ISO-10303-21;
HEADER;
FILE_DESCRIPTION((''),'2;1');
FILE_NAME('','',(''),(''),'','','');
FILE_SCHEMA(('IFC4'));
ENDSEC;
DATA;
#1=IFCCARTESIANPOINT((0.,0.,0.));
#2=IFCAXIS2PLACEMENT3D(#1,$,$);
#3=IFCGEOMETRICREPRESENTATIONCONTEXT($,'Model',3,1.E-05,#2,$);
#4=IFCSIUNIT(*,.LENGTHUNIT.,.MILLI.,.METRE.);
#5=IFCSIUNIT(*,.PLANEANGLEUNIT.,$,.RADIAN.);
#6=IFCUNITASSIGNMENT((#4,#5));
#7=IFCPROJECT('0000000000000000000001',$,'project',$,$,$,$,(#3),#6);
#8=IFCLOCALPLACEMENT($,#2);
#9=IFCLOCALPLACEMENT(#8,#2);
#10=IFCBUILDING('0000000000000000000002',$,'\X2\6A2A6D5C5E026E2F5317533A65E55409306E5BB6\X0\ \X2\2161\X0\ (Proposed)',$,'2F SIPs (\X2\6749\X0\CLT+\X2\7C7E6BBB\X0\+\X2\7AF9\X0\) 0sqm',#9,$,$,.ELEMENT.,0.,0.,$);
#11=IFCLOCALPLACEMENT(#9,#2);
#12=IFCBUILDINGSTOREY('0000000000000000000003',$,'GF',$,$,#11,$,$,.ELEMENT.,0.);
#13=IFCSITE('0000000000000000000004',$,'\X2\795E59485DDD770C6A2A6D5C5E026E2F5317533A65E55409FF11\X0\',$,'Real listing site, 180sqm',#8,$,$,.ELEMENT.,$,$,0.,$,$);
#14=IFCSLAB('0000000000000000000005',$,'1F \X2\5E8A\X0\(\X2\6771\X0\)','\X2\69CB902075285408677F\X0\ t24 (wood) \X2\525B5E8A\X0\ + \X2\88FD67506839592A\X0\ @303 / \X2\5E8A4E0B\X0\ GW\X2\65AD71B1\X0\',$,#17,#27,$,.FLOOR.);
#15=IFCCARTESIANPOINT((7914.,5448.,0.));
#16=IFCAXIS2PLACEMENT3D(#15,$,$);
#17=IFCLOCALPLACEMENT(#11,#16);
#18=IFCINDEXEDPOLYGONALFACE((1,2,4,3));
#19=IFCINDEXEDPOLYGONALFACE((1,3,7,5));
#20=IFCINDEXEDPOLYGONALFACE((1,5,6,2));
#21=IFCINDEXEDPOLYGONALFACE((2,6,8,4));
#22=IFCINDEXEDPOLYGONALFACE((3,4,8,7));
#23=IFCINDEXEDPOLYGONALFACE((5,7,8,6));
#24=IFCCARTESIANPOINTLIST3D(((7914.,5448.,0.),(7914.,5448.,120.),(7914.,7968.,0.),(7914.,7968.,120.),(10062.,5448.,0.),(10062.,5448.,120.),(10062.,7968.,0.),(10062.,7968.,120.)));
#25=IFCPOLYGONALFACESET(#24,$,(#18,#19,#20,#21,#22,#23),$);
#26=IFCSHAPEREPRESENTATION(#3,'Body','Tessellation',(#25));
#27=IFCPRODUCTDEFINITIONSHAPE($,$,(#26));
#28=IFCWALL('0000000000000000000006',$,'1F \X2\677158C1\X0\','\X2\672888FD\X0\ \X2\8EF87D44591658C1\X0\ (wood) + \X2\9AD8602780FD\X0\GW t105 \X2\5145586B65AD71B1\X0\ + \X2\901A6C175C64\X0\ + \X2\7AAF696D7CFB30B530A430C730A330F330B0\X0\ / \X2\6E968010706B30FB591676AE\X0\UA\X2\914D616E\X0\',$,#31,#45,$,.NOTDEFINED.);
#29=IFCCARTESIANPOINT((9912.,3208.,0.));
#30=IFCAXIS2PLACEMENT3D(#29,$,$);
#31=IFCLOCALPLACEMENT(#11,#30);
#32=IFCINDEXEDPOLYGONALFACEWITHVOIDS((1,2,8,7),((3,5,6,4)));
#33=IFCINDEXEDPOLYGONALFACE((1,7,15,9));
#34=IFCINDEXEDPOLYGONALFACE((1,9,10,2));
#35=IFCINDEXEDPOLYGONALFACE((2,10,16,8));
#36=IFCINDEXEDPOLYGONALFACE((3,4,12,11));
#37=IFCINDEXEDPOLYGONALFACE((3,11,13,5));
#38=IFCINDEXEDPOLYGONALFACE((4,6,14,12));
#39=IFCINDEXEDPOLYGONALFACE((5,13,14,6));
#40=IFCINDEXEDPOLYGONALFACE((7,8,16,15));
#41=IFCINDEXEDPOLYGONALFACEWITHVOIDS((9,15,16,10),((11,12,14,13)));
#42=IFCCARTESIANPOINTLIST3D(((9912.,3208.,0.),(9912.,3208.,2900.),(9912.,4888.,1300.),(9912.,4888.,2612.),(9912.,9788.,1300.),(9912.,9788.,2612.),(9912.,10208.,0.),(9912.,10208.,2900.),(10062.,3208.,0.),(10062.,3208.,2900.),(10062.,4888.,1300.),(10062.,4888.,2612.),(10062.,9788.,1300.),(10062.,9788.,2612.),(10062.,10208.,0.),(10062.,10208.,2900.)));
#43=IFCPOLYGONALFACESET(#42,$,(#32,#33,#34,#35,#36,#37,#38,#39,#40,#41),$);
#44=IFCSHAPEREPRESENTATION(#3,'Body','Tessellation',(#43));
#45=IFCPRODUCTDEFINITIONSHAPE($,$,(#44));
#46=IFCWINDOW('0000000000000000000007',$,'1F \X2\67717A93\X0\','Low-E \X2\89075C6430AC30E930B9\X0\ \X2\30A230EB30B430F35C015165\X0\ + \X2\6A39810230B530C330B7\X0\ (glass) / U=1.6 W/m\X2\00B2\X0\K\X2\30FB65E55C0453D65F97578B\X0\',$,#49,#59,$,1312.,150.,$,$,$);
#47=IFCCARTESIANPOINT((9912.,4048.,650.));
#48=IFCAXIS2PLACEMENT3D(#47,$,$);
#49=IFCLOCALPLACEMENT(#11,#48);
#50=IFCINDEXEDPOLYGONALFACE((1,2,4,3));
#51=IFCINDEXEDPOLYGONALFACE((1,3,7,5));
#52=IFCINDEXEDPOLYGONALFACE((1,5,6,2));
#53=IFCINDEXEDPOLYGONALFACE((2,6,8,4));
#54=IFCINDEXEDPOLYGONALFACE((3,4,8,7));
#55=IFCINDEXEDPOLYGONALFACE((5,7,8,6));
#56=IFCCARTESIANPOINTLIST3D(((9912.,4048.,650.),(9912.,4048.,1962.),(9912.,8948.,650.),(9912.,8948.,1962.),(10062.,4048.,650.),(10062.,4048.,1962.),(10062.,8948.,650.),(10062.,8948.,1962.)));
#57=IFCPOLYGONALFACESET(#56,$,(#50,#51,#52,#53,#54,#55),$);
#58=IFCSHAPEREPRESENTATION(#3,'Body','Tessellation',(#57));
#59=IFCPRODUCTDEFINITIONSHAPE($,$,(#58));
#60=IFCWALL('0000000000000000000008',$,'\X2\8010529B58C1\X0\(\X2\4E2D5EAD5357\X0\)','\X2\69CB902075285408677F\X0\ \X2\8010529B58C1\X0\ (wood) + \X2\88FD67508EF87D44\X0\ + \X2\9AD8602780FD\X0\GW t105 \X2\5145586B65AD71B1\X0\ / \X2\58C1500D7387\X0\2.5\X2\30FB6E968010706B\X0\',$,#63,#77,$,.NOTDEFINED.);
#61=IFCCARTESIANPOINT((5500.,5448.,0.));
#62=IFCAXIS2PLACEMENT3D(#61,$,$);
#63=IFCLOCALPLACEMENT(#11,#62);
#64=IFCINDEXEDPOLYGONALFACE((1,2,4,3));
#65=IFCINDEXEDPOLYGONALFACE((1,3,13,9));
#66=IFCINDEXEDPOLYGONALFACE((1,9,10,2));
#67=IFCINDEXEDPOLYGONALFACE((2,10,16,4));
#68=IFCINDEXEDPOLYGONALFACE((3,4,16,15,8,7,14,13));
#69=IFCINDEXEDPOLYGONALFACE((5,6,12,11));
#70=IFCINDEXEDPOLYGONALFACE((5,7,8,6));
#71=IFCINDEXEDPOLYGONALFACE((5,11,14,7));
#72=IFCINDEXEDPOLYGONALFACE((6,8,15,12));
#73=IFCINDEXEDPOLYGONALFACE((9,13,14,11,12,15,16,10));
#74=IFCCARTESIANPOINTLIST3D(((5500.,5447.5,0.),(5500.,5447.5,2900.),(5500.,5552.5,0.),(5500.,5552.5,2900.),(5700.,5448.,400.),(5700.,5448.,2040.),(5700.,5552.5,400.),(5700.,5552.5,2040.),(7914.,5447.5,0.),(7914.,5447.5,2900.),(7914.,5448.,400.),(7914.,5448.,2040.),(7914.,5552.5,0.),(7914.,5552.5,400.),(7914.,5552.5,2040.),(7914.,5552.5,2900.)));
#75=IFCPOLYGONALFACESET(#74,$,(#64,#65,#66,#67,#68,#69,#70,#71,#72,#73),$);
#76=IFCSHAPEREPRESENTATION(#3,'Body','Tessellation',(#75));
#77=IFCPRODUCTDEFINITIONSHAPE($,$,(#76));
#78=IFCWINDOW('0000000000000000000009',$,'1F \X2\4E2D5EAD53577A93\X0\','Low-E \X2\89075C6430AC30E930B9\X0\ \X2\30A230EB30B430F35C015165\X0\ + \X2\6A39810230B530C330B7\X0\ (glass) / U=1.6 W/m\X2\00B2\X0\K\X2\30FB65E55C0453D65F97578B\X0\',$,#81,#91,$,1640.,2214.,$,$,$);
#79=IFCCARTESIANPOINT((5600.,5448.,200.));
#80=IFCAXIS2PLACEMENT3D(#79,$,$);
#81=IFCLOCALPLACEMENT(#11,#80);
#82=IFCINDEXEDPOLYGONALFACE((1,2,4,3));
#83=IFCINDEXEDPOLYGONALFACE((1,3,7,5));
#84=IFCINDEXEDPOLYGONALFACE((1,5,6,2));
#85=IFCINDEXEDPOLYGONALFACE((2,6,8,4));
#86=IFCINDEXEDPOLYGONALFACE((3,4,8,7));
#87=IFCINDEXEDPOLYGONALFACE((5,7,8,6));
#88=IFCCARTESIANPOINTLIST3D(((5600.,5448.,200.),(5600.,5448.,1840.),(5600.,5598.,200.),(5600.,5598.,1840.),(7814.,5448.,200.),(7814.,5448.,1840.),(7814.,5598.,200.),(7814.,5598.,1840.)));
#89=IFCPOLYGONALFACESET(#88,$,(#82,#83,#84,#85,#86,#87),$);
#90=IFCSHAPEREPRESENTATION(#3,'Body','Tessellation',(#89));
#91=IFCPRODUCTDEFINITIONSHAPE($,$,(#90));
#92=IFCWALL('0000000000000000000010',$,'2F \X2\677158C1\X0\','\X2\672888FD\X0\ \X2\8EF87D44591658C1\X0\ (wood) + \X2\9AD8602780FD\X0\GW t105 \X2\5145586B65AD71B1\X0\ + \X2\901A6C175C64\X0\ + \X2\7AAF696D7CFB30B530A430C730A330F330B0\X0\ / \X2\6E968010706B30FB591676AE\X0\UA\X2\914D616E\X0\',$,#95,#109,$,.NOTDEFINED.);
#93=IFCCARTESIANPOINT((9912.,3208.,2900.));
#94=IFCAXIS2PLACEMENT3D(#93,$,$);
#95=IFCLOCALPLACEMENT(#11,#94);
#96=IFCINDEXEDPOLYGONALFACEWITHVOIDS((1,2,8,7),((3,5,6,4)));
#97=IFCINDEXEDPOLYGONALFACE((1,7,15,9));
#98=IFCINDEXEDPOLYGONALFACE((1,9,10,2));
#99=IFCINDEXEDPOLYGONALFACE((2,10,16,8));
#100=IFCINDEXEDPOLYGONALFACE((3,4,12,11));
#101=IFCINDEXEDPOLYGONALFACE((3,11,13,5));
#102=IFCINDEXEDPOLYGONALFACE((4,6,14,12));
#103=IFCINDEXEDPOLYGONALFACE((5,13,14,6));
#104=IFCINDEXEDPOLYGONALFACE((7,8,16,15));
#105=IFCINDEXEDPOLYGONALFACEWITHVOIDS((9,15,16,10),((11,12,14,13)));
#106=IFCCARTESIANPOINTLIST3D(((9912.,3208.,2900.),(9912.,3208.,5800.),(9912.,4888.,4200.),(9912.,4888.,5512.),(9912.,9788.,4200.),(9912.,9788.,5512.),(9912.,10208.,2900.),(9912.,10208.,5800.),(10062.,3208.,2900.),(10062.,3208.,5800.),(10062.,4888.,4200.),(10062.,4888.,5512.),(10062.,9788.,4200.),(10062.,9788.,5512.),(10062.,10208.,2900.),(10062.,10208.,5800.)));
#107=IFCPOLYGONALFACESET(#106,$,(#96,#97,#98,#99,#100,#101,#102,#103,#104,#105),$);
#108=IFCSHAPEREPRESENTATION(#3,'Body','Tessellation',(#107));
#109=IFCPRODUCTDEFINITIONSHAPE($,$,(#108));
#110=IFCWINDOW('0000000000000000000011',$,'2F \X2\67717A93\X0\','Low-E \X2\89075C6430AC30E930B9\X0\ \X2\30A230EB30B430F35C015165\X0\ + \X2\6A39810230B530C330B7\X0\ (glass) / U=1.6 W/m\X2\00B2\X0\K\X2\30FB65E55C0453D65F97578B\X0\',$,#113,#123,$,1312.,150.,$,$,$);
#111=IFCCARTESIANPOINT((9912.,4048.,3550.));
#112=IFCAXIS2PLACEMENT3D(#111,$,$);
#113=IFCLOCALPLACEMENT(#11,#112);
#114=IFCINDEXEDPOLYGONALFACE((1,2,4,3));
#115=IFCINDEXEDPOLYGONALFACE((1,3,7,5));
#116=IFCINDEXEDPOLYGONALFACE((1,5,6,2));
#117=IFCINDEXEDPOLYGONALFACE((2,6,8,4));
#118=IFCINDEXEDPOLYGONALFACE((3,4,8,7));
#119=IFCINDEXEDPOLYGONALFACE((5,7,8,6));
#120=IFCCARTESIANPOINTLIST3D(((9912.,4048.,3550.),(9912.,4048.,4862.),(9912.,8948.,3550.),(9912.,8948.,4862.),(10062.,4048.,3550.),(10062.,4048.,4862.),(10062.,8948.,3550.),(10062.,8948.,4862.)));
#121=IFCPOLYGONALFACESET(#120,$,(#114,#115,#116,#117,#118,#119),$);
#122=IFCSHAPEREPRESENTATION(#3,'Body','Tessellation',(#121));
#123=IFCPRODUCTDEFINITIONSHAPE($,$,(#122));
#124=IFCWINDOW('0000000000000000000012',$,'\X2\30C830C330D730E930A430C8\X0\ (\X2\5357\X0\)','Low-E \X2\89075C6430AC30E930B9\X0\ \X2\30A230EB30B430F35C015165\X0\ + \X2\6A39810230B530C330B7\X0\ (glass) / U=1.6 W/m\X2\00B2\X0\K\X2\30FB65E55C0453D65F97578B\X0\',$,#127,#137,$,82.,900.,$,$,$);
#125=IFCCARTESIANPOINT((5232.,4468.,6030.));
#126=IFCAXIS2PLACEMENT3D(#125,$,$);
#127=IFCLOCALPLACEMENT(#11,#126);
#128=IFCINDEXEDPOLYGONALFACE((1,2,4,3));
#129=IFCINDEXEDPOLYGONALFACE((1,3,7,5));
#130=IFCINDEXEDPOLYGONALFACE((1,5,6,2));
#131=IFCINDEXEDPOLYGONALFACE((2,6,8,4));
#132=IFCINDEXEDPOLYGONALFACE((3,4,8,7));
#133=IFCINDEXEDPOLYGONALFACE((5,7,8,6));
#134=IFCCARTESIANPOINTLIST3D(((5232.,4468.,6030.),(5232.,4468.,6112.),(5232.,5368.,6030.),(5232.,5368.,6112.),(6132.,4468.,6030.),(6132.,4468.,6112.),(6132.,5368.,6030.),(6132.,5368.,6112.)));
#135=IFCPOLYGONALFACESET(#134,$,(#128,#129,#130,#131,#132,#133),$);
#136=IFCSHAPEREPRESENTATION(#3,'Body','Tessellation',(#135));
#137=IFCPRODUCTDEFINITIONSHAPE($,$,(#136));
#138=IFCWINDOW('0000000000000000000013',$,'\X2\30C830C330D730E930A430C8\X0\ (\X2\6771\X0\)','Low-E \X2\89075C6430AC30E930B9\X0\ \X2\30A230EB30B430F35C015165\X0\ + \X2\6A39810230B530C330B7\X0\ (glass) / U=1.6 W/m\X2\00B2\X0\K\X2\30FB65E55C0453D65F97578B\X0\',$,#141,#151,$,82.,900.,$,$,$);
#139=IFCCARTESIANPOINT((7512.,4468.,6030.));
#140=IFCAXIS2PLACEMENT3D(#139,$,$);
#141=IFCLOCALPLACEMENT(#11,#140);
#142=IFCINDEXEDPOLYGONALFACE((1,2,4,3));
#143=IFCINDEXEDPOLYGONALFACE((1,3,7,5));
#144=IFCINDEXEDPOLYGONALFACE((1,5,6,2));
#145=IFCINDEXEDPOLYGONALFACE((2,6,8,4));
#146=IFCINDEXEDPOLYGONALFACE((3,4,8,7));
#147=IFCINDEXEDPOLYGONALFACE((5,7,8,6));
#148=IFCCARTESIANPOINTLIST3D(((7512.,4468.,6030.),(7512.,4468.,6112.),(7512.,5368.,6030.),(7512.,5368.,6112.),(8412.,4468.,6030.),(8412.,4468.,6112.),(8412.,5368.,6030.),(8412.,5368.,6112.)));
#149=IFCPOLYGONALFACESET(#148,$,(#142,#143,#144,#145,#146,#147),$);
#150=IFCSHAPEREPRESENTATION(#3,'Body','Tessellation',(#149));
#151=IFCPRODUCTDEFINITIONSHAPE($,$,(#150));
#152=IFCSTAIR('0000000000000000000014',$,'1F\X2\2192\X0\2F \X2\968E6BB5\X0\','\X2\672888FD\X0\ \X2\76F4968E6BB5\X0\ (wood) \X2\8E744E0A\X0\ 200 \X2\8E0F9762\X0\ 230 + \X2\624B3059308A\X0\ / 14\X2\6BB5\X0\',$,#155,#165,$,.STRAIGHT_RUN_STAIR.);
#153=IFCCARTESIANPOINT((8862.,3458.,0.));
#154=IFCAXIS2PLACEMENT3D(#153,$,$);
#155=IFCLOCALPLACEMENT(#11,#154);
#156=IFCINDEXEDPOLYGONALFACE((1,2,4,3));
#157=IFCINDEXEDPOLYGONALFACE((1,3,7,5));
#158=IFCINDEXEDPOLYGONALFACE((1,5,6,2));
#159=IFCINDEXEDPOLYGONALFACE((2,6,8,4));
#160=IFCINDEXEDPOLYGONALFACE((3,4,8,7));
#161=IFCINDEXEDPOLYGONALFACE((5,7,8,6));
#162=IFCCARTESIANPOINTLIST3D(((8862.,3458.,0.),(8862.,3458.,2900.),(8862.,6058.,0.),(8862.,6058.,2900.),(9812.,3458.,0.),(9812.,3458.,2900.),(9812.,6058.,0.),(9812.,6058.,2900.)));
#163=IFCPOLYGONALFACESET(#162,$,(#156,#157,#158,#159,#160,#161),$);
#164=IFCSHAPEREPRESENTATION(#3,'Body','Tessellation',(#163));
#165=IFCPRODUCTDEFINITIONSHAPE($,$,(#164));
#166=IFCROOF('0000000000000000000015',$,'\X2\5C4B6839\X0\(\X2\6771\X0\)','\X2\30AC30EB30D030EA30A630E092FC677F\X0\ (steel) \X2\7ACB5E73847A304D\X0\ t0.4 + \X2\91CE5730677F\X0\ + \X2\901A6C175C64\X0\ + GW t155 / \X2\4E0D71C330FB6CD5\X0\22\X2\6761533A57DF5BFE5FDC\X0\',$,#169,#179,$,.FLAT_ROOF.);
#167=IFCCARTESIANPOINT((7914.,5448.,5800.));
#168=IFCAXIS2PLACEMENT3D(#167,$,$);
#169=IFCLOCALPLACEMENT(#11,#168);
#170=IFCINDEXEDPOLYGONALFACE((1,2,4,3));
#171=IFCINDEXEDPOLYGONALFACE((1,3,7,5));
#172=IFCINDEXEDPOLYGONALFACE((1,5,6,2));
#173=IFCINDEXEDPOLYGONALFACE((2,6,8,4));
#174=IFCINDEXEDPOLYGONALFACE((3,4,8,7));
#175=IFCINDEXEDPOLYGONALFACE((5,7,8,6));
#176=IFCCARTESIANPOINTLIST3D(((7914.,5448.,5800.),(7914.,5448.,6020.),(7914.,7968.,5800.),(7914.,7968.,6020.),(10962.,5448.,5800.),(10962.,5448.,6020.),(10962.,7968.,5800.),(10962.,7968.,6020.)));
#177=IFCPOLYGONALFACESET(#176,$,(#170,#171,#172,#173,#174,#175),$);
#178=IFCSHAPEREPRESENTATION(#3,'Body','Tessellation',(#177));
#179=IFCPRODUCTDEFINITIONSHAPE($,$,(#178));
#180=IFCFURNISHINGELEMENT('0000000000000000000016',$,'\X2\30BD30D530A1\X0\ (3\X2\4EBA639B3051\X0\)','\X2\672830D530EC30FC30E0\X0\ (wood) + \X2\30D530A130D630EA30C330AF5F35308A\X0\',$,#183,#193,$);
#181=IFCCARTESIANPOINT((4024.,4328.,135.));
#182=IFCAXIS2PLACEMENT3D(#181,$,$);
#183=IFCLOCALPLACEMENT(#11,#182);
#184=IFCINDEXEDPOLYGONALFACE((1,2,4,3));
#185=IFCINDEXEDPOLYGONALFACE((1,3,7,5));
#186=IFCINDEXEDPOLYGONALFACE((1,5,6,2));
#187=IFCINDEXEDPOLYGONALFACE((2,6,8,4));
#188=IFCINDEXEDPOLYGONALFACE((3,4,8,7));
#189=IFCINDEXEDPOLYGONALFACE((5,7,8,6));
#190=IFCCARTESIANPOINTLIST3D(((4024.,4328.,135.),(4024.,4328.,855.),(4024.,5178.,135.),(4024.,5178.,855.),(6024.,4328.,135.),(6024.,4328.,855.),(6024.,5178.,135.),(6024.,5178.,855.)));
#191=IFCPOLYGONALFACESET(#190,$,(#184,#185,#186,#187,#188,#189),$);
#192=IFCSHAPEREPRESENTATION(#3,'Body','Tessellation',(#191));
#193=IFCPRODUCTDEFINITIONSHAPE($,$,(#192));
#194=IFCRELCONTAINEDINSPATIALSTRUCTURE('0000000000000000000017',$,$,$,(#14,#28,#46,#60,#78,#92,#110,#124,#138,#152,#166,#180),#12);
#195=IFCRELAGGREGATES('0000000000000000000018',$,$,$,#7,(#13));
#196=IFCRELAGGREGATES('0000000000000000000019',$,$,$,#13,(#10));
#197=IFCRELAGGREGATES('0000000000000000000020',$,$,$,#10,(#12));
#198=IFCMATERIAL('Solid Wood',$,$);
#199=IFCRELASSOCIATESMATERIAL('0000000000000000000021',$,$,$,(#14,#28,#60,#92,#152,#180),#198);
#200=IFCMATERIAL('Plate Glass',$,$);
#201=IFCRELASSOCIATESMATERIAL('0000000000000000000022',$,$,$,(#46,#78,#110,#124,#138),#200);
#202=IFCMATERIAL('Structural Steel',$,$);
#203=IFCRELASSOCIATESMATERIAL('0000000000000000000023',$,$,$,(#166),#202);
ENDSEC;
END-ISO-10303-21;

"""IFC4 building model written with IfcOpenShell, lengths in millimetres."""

from ifc_helpers import new_model, si_unit, frame, frame_2d, origin, place, context, project, spatial, rectangle, extrude, material, element, fill, save


model = new_model("IFC4")

# Units and contexts
model_context = context("Model", 3, precision=1e-05, world=origin())
ifc_project = project(units=[si_unit("LENGTHUNIT", "METRE", prefix="MILLI"), si_unit("PLANEANGLEUNIT", "RADIAN")], contexts=[model_context])

# Site, building, storey
site_placement = place(None, origin())
site = spatial("IfcSite", under=ifc_project, at=site_placement, Name="神奈川県横浜市港北区日吉１", ObjectType="Real listing site, 180sqm", CompositionType="ELEMENT", RefElevation=0.0)
building_placement = place(site_placement, origin())
building = spatial("IfcBuilding", under=site, at=building_placement, Name="横浜市港北区日吉の家 Ⅱ (Proposed)", ObjectType="2F SIPs (杉CLT+籾殻+竹) 0sqm", CompositionType="ELEMENT", ElevationOfRefHeight=0.0, ElevationOfTerrain=0.0)
storey_placement = place(building_placement, origin())
storey = spatial("IfcBuildingStorey", under=building, at=storey_placement, Name="GF", CompositionType="ELEMENT", Elevation=0.0)

# Slab
ifc_material_1 = material(Name="Solid Wood")
slab_placement = place(storey_placement, frame((7914.0, 5448.0, 0.0)))
element("IfcSlab", 1, at=slab_placement, inside=storey, material=ifc_material_1, Name="1F 床(東)", Description="構造用合板 t24 (wood) 剛床 + 製材根太 @303 / 床下 GW断熱", PredefinedType="FLOOR", context=model_context, shape_type="SweptSolid", body=[
    extrude(rectangle(XDim=2148.0, YDim=2520.0, at=frame_2d((1074.0, 1260.0))), frame((7914.0, 5448.0, 0.0)), (0.0, 0.0, 1.0), 120.0),
])

# Walls, openings, windows
wall_1_placement = place(storey_placement, frame((9912.0, 3208.0, 0.0)))
wall_1 = element("IfcWall", 2, at=wall_1_placement, inside=storey, material=ifc_material_1, Name="1F 東壁", Description="木製 軸組外壁 (wood) + 高性能GW t105 充填断熱 + 通気層 + 窯業系サイディング / 準耐火・外皮UA配慮", PredefinedType="NOTDEFINED", context=model_context, shape_type="SweptSolid", body=[
    extrude(rectangle(XDim=150.0, YDim=7000.0, at=frame_2d((75.0, 3500.0))), frame((9912.0, 3208.0, 0.0)), (0.0, 0.0, 1.0), 2900.0),
])
opening_1_placement = place(storey_placement, frame((9912.0, 4048.0, 650.0)))
opening_1 = element("IfcOpeningElement", 3, at=opening_1_placement, cuts=wall_1, PredefinedType="NOTDEFINED", context=model_context, shape_type="SweptSolid", body=[
    extrude(rectangle(XDim=150.0, YDim=4900.0, at=frame_2d((75.0, 2450.0))), frame((9912.0, 4048.0, 650.0)), (0.0, 0.0, 1.0), 1312.0),
])
ifc_material_2 = material(Name="Plate Glass")
window_1_placement = place(storey_placement, frame((9912.0, 4048.0, 650.0)))
window_1 = element("IfcWindow", 4, at=window_1_placement, inside=storey, material=ifc_material_2, Name="1F 東窓", Description="Low-E 複層ガラス アルゴン封入 + 樹脂サッシ (glass) / U=1.6 W/m²K・日射取得型", OverallHeight=1312.0, OverallWidth=150.0, context=model_context, shape_type="SweptSolid", body=[
    extrude(rectangle(XDim=150.0, YDim=4900.0, at=frame_2d((75.0, 2450.0))), frame((9912.0, 4048.0, 650.0)), (0.0, 0.0, 1.0), 1312.0),
])
fill(opening_1, window_1)
wall_2_placement = place(storey_placement, frame((5500.0, 5448.0, 0.0)))
wall_2 = element("IfcWall", 5, at=wall_2_placement, inside=storey, material=ifc_material_1, Name="耐力壁(中庭南)", Description="構造用合板 耐力壁 (wood) + 製材軸組 + 高性能GW t105 充填断熱 / 壁倍率2.5・準耐火", PredefinedType="NOTDEFINED", context=model_context, shape_type="SweptSolid", body=[
    extrude(rectangle(XDim=2414.0, YDim=105.0, at=frame_2d((1207.0, 52.0))), frame((5500.0, 5448.0, 0.0)), (0.0, 0.0, 1.0), 2900.0),
])
opening_2_placement = place(storey_placement, frame((5600.0, 5448.0, 200.0)))
opening_2 = element("IfcOpeningElement", 6, at=opening_2_placement, cuts=wall_2, PredefinedType="NOTDEFINED", context=model_context, shape_type="SweptSolid", body=[
    extrude(rectangle(XDim=2214.0, YDim=150.0, at=frame_2d((1107.0, 75.0))), frame((5600.0, 5448.0, 200.0)), (0.0, 0.0, 1.0), 1640.0),
])
window_2_placement = place(storey_placement, frame((5600.0, 5448.0, 200.0)))
window_2 = element("IfcWindow", 7, at=window_2_placement, inside=storey, material=ifc_material_2, Name="1F 中庭南窓", Description="Low-E 複層ガラス アルゴン封入 + 樹脂サッシ (glass) / U=1.6 W/m²K・日射取得型", OverallHeight=1640.0, OverallWidth=2214.0, context=model_context, shape_type="SweptSolid", body=[
    extrude(rectangle(XDim=2214.0, YDim=150.0, at=frame_2d((1107.0, 75.0))), frame((5600.0, 5448.0, 200.0)), (0.0, 0.0, 1.0), 1640.0),
])
fill(opening_2, window_2)

# Wall, opening, window
wall_3_placement = place(storey_placement, frame((9912.0, 3208.0, 2900.0)))
wall_3 = element("IfcWall", 8, at=wall_3_placement, inside=storey, material=ifc_material_1, Name="2F 東壁", Description="木製 軸組外壁 (wood) + 高性能GW t105 充填断熱 + 通気層 + 窯業系サイディング / 準耐火・外皮UA配慮", PredefinedType="NOTDEFINED", context=model_context, shape_type="SweptSolid", body=[
    extrude(rectangle(XDim=150.0, YDim=7000.0, at=frame_2d((75.0, 3500.0))), frame((9912.0, 3208.0, 2900.0)), (0.0, 0.0, 1.0), 2900.0),
])
opening_3_placement = place(storey_placement, frame((9912.0, 4048.0, 3550.0)))
opening_3 = element("IfcOpeningElement", 9, at=opening_3_placement, cuts=wall_3, PredefinedType="NOTDEFINED", context=model_context, shape_type="SweptSolid", body=[
    extrude(rectangle(XDim=150.0, YDim=4900.0, at=frame_2d((75.0, 2450.0))), frame((9912.0, 4048.0, 3550.0)), (0.0, 0.0, 1.0), 1312.0),
])
window_3_placement = place(storey_placement, frame((9912.0, 4048.0, 3550.0)))
window_3 = element("IfcWindow", 10, at=window_3_placement, inside=storey, material=ifc_material_2, Name="2F 東窓", Description="Low-E 複層ガラス アルゴン封入 + 樹脂サッシ (glass) / U=1.6 W/m²K・日射取得型", OverallHeight=1312.0, OverallWidth=150.0, context=model_context, shape_type="SweptSolid", body=[
    extrude(rectangle(XDim=150.0, YDim=4900.0, at=frame_2d((75.0, 2450.0))), frame((9912.0, 4048.0, 3550.0)), (0.0, 0.0, 1.0), 1312.0),
])
fill(opening_3, window_3)

# Windows
window_4_placement = place(storey_placement, frame((5232.0, 4468.0, 6030.0)))
element("IfcWindow", 11, at=window_4_placement, inside=storey, material=ifc_material_2, Name="トップライト (南)", Description="Low-E 複層ガラス アルゴン封入 + 樹脂サッシ (glass) / U=1.6 W/m²K・日射取得型", OverallHeight=82.0, OverallWidth=900.0, context=model_context, shape_type="SweptSolid", body=[
    extrude(rectangle(XDim=900.0, YDim=900.0, at=frame_2d((450.0, 450.0))), frame((5232.0, 4468.0, 6030.0)), (0.0, 0.0, 1.0), 82.0),
])
window_5_placement = place(storey_placement, frame((7512.0, 4468.0, 6030.0)))
element("IfcWindow", 12, at=window_5_placement, inside=storey, material=ifc_material_2, Name="トップライト (東)", Description="Low-E 複層ガラス アルゴン封入 + 樹脂サッシ (glass) / U=1.6 W/m²K・日射取得型", OverallHeight=82.0, OverallWidth=900.0, context=model_context, shape_type="SweptSolid", body=[
    extrude(rectangle(XDim=900.0, YDim=900.0, at=frame_2d((450.0, 450.0))), frame((7512.0, 4468.0, 6030.0)), (0.0, 0.0, 1.0), 82.0),
])

# Stair
stair_placement = place(storey_placement, frame((8862.0, 3458.0, 0.0)))
element("IfcStair", 13, at=stair_placement, inside=storey, material=ifc_material_1, Name="1F→2F 階段", Description="木製 直階段 (wood) 蹴上 200 踏面 230 + 手すり / 14段", PredefinedType="STRAIGHT_RUN_STAIR", context=model_context, shape_type="SweptSolid", body=[
    extrude(rectangle(XDim=950.0, YDim=2600.0, at=frame_2d((475.0, 1300.0))), frame((8862.0, 3458.0, 0.0)), (0.0, 0.0, 1.0), 2900.0),
])

# Roof
ifc_material_3 = material(Name="Structural Steel")
roof_placement = place(storey_placement, frame((7914.0, 5448.0, 5800.0)))
element("IfcRoof", 14, at=roof_placement, inside=storey, material=ifc_material_3, Name="屋根(東)", Description="ガルバリウム鋼板 (steel) 立平葺き t0.4 + 野地板 + 通気層 + GW t155 / 不燃・法22条区域対応", PredefinedType="FLAT_ROOF", context=model_context, shape_type="SweptSolid", body=[
    extrude(rectangle(XDim=3048.0, YDim=2520.0, at=frame_2d((1524.0, 1260.0))), frame((7914.0, 5448.0, 5800.0)), (0.0, 0.0, 1.0), 220.0),
])

# Furnishing element
furnishing_1_placement = place(storey_placement, frame((4024.0, 4328.0, 135.0)))
element("IfcFurnishingElement", 15, at=furnishing_1_placement, inside=storey, material=ifc_material_1, Name="ソファ (3人掛け)", Description="木フレーム (wood) + ファブリック張り", context=model_context, shape_type="SweptSolid", body=[
    extrude(rectangle(XDim=2000.0, YDim=850.0, at=frame_2d((1000.0, 425.0))), frame((4024.0, 4328.0, 135.0)), (0.0, 0.0, 1.0), 720.0),
])

save(model, "model.ifc")
